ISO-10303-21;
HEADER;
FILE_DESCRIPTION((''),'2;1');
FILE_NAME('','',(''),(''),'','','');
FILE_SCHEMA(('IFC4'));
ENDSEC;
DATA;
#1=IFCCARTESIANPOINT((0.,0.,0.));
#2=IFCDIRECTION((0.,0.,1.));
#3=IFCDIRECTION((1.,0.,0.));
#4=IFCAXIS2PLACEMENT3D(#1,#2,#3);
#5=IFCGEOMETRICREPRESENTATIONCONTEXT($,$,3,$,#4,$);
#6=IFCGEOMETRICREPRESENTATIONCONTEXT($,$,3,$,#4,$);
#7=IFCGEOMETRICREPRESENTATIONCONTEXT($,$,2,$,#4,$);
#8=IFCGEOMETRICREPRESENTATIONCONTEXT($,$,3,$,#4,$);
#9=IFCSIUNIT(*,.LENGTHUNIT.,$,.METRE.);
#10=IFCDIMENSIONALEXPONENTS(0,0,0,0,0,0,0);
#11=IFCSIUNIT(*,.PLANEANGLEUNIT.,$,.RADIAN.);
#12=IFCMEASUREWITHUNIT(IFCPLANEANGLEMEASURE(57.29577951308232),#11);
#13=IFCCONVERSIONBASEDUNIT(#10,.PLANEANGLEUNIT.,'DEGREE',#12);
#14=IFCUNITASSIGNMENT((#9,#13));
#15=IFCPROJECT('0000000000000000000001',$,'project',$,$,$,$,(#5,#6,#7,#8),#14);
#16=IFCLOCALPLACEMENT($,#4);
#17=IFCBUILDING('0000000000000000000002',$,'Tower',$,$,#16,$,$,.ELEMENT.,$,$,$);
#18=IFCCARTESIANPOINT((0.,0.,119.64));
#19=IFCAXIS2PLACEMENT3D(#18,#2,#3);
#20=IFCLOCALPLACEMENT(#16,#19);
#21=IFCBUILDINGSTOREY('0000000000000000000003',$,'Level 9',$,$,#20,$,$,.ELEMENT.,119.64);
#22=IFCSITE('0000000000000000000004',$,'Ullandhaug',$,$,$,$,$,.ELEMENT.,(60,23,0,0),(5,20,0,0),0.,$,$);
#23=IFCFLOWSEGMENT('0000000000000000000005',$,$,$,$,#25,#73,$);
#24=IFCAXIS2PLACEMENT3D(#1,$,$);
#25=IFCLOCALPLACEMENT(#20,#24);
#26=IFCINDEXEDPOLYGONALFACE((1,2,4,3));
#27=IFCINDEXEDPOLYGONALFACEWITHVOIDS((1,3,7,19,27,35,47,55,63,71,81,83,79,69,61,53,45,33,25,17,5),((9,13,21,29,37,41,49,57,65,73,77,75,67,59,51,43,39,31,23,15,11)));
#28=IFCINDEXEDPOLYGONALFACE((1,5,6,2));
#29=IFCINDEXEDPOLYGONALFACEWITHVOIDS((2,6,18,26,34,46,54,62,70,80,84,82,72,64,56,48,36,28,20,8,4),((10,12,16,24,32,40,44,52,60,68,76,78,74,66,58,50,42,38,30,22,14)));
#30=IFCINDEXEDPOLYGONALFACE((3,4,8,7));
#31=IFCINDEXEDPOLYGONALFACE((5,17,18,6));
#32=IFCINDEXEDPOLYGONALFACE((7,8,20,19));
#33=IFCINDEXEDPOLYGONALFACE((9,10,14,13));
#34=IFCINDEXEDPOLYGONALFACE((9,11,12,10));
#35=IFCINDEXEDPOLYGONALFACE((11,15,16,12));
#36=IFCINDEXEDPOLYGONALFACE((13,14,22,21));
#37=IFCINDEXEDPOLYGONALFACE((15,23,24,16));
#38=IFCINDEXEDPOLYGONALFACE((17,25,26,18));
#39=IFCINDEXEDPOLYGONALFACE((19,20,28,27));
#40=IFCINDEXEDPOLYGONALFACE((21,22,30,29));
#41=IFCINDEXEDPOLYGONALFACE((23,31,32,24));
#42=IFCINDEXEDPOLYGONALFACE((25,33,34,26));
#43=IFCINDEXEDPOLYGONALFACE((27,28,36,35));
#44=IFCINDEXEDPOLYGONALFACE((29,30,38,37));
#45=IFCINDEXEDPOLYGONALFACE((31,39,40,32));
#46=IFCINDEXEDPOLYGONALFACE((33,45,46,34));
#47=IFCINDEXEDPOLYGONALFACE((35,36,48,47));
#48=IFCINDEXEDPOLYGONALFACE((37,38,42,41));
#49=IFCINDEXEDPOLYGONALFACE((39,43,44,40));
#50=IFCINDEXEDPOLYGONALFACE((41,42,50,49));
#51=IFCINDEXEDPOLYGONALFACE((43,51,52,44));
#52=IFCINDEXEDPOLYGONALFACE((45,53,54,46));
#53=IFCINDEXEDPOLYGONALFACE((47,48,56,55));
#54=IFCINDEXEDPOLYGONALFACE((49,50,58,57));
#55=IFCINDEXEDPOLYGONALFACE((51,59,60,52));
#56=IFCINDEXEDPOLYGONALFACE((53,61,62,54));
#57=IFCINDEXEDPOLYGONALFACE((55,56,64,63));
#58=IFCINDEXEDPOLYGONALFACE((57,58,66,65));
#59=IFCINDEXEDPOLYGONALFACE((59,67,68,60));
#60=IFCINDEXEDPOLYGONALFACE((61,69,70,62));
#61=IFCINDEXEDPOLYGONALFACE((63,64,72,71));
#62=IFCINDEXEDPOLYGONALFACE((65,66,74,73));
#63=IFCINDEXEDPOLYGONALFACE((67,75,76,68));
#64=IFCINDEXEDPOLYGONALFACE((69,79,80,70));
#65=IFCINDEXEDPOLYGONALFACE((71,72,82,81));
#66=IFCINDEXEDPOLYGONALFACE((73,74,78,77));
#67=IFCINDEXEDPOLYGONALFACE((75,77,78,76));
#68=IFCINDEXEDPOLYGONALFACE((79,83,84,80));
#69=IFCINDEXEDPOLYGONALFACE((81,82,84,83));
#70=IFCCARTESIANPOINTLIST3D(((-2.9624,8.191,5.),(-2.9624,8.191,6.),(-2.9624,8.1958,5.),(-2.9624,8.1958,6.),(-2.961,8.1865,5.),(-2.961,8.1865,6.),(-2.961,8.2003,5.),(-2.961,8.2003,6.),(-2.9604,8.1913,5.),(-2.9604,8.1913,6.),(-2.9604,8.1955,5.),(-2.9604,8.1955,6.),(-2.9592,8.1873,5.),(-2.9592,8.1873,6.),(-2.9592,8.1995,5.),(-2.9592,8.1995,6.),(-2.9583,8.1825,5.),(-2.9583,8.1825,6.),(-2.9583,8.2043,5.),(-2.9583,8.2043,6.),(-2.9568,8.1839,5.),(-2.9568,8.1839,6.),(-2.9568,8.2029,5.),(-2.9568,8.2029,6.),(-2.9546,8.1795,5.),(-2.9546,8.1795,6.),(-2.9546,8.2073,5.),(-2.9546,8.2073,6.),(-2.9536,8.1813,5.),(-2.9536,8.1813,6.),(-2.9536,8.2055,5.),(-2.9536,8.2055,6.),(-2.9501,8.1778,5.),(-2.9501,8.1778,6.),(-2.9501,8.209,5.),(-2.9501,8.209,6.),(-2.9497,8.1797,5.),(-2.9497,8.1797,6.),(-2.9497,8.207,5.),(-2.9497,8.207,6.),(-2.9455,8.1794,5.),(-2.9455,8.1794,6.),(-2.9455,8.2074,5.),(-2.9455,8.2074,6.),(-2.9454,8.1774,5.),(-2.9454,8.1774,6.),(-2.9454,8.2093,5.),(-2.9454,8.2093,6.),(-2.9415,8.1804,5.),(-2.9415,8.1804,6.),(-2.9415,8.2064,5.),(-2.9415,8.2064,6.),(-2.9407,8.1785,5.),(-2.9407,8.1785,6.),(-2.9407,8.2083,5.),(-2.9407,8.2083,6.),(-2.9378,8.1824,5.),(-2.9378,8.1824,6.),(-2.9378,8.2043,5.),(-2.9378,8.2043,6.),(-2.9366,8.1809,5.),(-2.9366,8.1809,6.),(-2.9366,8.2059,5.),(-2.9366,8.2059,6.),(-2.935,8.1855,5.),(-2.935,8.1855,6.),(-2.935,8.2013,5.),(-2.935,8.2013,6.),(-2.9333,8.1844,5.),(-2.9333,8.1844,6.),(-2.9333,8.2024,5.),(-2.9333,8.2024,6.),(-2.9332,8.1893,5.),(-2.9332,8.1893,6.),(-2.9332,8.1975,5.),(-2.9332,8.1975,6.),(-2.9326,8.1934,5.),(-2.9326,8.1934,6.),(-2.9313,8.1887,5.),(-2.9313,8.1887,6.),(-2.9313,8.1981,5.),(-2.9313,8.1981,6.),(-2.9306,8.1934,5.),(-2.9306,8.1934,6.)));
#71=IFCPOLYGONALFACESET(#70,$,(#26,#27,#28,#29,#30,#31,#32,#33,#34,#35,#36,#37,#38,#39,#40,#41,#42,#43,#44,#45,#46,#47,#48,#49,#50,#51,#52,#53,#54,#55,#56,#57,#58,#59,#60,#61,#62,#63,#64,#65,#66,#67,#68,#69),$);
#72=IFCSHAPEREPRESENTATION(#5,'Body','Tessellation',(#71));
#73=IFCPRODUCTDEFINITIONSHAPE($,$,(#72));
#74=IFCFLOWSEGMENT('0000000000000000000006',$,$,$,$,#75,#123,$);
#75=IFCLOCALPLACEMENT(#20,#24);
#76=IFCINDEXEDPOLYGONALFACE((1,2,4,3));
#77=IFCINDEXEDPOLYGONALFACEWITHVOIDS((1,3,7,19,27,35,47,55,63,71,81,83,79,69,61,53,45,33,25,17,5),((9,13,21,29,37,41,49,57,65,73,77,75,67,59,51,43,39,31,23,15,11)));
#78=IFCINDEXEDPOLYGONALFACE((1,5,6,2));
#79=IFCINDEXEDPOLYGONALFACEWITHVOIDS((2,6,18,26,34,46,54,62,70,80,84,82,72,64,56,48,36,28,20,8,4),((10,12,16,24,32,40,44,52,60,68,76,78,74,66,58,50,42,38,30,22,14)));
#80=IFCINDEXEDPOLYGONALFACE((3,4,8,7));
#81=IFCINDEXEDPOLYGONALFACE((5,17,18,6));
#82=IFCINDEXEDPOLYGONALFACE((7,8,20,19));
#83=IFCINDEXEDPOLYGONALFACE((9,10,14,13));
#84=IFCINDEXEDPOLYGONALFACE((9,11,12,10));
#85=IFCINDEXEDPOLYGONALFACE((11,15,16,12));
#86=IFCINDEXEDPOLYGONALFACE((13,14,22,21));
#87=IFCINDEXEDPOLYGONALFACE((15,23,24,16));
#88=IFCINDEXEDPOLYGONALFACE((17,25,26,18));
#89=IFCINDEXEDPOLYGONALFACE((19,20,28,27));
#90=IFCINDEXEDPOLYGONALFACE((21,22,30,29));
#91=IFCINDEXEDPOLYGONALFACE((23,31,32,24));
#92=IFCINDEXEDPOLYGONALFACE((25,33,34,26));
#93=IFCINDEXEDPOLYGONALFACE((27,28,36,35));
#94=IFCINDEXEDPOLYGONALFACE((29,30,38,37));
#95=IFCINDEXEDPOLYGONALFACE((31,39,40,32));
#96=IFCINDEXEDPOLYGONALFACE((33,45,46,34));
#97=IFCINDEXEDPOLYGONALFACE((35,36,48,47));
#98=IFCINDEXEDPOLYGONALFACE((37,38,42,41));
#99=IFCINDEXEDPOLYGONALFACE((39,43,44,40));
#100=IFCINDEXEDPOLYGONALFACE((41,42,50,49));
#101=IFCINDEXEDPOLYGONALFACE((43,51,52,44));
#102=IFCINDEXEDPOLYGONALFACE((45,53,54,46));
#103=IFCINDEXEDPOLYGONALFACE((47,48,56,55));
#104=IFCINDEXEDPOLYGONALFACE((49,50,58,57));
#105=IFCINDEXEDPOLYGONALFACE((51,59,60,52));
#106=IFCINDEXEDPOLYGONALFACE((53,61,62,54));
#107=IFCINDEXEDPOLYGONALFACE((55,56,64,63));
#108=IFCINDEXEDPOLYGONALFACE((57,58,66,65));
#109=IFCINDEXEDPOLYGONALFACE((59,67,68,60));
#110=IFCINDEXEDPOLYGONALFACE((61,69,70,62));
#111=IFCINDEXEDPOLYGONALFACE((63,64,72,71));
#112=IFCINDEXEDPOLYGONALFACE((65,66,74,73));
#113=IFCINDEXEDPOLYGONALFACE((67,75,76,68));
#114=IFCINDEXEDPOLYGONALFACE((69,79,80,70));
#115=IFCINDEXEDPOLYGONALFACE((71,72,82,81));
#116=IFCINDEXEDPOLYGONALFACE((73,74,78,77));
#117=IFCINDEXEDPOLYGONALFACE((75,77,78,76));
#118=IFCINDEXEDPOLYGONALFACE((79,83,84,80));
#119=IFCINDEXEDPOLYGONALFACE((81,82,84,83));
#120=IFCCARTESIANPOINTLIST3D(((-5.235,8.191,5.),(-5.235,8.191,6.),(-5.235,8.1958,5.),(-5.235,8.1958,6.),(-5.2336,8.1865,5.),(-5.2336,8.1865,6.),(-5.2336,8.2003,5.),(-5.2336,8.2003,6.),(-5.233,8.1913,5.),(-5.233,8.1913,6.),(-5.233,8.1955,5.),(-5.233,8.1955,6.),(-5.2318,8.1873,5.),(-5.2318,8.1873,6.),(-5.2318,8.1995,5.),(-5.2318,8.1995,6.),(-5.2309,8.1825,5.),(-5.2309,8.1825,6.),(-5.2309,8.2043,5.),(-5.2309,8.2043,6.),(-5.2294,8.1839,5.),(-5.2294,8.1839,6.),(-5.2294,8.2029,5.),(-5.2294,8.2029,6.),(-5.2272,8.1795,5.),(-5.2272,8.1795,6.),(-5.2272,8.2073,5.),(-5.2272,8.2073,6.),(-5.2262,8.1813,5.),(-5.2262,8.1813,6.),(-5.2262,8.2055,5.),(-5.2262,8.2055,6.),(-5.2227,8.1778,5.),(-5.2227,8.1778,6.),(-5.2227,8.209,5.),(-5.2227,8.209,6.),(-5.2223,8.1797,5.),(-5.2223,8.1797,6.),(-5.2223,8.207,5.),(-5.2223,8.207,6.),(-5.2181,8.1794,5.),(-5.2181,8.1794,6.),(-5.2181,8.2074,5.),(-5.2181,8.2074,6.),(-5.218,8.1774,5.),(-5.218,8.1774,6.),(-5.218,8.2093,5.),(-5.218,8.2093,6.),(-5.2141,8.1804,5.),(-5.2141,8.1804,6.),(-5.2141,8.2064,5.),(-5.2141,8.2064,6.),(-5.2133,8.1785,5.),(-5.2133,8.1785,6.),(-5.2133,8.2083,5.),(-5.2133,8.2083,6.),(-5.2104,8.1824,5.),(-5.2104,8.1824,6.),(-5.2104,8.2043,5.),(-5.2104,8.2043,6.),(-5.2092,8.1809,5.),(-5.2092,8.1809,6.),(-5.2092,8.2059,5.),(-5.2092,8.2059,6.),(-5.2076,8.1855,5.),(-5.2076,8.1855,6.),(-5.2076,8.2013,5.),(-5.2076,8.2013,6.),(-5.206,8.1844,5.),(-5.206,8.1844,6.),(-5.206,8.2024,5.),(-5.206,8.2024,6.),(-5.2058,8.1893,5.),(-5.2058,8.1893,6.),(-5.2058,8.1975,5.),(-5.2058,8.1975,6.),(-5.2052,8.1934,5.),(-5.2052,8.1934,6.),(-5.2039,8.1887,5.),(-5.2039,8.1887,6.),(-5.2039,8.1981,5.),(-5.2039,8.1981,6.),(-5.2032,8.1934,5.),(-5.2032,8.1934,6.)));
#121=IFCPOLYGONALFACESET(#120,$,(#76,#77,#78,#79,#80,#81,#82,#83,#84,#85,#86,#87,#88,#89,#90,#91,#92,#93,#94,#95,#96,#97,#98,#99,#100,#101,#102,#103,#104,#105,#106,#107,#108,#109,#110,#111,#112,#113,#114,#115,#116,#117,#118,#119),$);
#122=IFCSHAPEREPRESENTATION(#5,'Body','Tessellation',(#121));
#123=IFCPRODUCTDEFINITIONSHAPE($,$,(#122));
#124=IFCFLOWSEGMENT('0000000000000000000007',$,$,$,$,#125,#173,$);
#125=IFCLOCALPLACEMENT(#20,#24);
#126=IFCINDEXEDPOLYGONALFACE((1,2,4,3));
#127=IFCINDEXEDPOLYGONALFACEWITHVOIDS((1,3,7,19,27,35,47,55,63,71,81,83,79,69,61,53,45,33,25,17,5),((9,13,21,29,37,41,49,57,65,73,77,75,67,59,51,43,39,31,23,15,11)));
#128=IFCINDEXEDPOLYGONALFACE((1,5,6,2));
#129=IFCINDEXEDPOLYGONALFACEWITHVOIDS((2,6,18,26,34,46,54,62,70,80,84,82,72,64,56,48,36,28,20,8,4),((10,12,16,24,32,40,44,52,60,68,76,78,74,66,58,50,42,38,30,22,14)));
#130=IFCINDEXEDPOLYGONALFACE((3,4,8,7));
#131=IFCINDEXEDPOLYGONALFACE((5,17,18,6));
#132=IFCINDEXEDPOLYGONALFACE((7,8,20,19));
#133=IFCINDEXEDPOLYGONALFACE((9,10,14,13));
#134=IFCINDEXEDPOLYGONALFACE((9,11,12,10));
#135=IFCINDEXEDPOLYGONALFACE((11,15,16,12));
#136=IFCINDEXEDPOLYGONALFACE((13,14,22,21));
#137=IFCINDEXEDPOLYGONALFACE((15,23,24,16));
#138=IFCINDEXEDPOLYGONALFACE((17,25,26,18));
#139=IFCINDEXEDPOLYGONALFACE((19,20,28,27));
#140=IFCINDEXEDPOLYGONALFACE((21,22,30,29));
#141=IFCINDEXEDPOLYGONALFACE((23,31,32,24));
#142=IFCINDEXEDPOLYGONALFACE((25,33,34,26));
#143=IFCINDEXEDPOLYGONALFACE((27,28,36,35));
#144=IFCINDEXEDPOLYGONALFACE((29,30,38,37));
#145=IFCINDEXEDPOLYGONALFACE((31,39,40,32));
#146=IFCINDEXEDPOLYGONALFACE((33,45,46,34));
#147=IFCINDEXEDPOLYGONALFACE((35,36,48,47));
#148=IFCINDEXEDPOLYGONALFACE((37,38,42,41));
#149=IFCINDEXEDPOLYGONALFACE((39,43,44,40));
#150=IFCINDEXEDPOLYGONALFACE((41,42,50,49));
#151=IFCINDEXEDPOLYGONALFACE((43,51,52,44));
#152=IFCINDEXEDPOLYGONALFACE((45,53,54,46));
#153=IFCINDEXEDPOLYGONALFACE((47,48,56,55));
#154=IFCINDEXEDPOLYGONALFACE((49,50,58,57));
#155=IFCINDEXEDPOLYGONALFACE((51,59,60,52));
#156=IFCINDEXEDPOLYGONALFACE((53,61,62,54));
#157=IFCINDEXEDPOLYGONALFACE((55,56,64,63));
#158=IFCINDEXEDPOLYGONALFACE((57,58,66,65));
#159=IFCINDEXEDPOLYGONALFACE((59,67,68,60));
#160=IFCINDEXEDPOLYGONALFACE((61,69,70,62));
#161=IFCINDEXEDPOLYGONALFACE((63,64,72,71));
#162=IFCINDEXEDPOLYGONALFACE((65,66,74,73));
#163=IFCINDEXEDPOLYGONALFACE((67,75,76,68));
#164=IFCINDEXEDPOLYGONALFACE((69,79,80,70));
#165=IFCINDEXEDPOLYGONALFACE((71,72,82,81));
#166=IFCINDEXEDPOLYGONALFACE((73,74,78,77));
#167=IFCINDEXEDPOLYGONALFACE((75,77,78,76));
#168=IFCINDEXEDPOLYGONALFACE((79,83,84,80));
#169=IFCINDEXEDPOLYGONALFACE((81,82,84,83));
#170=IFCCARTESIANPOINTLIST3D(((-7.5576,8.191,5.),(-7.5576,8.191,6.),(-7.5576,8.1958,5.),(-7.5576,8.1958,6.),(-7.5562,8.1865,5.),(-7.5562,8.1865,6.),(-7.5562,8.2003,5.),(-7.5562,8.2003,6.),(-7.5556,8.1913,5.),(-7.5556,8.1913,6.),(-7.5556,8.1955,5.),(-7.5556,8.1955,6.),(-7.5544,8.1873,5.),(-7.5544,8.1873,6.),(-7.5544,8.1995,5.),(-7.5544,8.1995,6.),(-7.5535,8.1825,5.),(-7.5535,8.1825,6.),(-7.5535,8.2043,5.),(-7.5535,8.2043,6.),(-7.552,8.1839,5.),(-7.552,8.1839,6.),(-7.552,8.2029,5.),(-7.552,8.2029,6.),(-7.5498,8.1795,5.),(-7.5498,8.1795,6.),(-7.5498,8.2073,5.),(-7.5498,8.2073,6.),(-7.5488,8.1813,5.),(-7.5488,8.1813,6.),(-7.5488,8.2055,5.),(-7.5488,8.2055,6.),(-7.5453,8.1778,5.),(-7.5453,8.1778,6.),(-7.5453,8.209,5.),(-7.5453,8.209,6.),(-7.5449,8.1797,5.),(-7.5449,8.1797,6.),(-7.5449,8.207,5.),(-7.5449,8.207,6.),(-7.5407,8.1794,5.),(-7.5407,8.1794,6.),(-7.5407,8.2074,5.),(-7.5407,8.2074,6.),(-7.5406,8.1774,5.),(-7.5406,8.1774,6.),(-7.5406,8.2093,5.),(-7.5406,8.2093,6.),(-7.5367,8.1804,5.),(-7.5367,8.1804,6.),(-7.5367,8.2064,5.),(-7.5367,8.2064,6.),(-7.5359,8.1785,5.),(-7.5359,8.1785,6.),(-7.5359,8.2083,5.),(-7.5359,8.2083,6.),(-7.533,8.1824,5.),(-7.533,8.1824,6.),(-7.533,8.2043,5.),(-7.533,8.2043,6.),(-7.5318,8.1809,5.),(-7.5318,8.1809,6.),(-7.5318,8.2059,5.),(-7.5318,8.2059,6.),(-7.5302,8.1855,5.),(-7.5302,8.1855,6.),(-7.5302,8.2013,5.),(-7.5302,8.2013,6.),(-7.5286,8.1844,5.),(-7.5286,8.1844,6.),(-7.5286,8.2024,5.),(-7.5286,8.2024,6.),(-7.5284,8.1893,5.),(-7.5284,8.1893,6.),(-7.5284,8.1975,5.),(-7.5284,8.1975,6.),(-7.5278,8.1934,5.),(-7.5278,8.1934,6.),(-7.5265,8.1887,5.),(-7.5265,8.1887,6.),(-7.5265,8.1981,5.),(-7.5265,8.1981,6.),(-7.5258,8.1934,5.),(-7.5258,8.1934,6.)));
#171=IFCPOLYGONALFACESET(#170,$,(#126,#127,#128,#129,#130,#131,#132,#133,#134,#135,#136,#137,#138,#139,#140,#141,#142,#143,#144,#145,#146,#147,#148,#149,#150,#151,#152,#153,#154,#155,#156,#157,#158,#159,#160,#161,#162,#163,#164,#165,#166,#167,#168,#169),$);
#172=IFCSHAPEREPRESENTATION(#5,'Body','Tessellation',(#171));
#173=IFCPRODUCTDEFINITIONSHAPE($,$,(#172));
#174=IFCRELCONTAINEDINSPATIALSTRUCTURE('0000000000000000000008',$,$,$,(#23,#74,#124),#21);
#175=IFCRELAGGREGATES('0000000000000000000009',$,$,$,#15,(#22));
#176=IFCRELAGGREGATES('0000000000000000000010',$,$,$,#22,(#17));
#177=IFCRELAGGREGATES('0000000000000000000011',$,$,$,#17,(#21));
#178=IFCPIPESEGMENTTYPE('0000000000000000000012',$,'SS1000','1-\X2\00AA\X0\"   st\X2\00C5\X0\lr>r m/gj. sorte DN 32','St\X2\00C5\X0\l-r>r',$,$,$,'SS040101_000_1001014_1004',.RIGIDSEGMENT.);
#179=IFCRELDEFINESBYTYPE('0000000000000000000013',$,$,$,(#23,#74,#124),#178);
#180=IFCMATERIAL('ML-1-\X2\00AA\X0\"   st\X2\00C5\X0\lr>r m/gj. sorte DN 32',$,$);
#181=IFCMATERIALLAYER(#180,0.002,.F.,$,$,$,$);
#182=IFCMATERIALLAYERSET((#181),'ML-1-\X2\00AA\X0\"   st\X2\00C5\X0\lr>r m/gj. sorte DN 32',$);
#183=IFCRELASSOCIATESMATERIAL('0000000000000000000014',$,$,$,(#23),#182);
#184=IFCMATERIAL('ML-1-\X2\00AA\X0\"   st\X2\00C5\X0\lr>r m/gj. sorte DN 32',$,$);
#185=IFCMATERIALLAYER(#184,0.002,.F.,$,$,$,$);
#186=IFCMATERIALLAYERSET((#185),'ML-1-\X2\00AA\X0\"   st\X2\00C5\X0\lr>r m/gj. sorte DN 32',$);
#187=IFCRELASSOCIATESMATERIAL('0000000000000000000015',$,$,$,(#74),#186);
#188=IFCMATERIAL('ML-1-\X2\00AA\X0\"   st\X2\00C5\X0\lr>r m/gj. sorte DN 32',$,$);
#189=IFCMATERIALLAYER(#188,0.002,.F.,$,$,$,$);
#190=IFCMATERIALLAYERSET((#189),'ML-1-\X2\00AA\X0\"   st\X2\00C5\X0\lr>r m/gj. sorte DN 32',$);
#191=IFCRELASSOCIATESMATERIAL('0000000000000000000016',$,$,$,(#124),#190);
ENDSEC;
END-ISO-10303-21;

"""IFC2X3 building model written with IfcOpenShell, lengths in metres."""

from ifc_helpers import new_model, entity, si_unit, converted_unit, frame, origin_with_axes, origin_2d_with_axis, place, context, project, spatial, hollow_circle, extrude, material, layer, layer_set, layer_usage, type_object, element, save


model = new_model("IFC2X3")

# Units and contexts
context_of_model_1 = context(None, 3, world=origin_with_axes())
context_of_model_2 = context(None, 3, world=origin_with_axes())
context_of_model_3 = context(None, 2, world=origin_with_axes())
context_of_model_4 = context(None, 3, world=origin_with_axes())
ifc_project = project(units=[si_unit("LENGTHUNIT", "METRE"), converted_unit("PLANEANGLEUNIT", "DEGREE", entity("IfcPlaneAngleMeasure", 57.29577951308232), si_unit("PLANEANGLEUNIT", "RADIAN"), dimensions=[0, 0, 0, 0, 0, 0, 0])], contexts=[context_of_model_1, context_of_model_2, context_of_model_3, context_of_model_4])

# Site, building, storey
site = spatial("IfcSite", under=ifc_project, Name="Ullandhaug", CompositionType="ELEMENT", RefLatitude=(60, 23, 0, 0), RefLongitude=(5, 20, 0, 0), RefElevation=0.0)
building_placement = place(None, origin_with_axes())
building = spatial("IfcBuilding", under=site, at=building_placement, Name="Tower", CompositionType="ELEMENT")
storey_placement = place(building_placement, frame((0.0, 0.0, 119.64), z_axis=(0.0, 0.0, 1.0), x_axis=(1.0, 0.0, 0.0)))
storey = spatial("IfcBuildingStorey", under=building, at=storey_placement, Name="Level 9", CompositionType="ELEMENT", Elevation=119.64)

# Flow segments
ifc_material_1 = material(Name="ML-1-ª\"   stÅlr>r m/gj. sorte DN 32")
ifc_layer_1 = layer(ifc_material_1, 0.002, ventilated=False)
ifc_layer_set_1 = layer_set([ifc_layer_1], Name="ML-1-ª\"   stÅlr>r m/gj. sorte DN 32")
ifc_layer_usage_1 = layer_usage(ifc_layer_set_1, "AXIS2", "POSITIVE", 0.0)
pipe_segment_type_1 = type_object("IfcPipeSegmentType", Name="SS1000", Description="1-ª\"   stÅlr>r m/gj. sorte DN 32", ApplicableOccurrence="StÅl-r>r", ElementType="SS040101_000_1001014_1004", PredefinedType="RIGIDSEGMENT")
flow_segment_1_placement = place(storey_placement, frame((-2.9466, 8.1934, 5.0), z_axis=(0.0, 0.0, 1.0), x_axis=(1.0, 0.0, 0.0)))
element("IfcFlowSegment", 1, at=flow_segment_1_placement, inside=storey, type_object=pipe_segment_type_1, material=ifc_layer_usage_1, context=context_of_model_1, shape_type="SweptSolid", body=[
    extrude(hollow_circle(Radius=0.016, WallThickness=0.002, at=origin_2d_with_axis()), origin_with_axes(), (0.0, 0.0, 1.0), 1.0),
])
ifc_material_2 = material(Name="ML-1-ª\"   stÅlr>r m/gj. sorte DN 32")
ifc_layer_2 = layer(ifc_material_2, 0.002, ventilated=False)
ifc_layer_set_2 = layer_set([ifc_layer_2], Name="ML-1-ª\"   stÅlr>r m/gj. sorte DN 32")
ifc_layer_usage_2 = layer_usage(ifc_layer_set_2, "AXIS2", "POSITIVE", 0.0)
flow_segment_2_placement = place(storey_placement, frame((-5.2192, 8.1934, 5.0), z_axis=(0.0, 0.0, 1.0), x_axis=(1.0, 0.0, 0.0)))
element("IfcFlowSegment", 2, at=flow_segment_2_placement, inside=storey, type_object=pipe_segment_type_1, material=ifc_layer_usage_2, context=context_of_model_1, shape_type="SweptSolid", body=[
    extrude(hollow_circle(Radius=0.016, WallThickness=0.002, at=origin_2d_with_axis()), origin_with_axes(), (0.0, 0.0, 1.0), 1.0),
])
ifc_material_3 = material(Name="ML-1-ª\"   stÅlr>r m/gj. sorte DN 32")
ifc_layer_3 = layer(ifc_material_3, 0.002, ventilated=False)
ifc_layer_set_3 = layer_set([ifc_layer_3], Name="ML-1-ª\"   stÅlr>r m/gj. sorte DN 32")
ifc_layer_usage_3 = layer_usage(ifc_layer_set_3, "AXIS2", "POSITIVE", 0.0)
flow_segment_3_placement = place(storey_placement, frame((-7.5418, 8.1934, 5.0), z_axis=(0.0, 0.0, 1.0), x_axis=(1.0, 0.0, 0.0)))
element("IfcFlowSegment", 3, at=flow_segment_3_placement, inside=storey, type_object=pipe_segment_type_1, material=ifc_layer_usage_3, context=context_of_model_1, shape_type="SweptSolid", body=[
    extrude(hollow_circle(Radius=0.016, WallThickness=0.002, at=origin_2d_with_axis()), origin_with_axes(), (0.0, 0.0, 1.0), 1.0),
])

save(model, "model.ifc")
